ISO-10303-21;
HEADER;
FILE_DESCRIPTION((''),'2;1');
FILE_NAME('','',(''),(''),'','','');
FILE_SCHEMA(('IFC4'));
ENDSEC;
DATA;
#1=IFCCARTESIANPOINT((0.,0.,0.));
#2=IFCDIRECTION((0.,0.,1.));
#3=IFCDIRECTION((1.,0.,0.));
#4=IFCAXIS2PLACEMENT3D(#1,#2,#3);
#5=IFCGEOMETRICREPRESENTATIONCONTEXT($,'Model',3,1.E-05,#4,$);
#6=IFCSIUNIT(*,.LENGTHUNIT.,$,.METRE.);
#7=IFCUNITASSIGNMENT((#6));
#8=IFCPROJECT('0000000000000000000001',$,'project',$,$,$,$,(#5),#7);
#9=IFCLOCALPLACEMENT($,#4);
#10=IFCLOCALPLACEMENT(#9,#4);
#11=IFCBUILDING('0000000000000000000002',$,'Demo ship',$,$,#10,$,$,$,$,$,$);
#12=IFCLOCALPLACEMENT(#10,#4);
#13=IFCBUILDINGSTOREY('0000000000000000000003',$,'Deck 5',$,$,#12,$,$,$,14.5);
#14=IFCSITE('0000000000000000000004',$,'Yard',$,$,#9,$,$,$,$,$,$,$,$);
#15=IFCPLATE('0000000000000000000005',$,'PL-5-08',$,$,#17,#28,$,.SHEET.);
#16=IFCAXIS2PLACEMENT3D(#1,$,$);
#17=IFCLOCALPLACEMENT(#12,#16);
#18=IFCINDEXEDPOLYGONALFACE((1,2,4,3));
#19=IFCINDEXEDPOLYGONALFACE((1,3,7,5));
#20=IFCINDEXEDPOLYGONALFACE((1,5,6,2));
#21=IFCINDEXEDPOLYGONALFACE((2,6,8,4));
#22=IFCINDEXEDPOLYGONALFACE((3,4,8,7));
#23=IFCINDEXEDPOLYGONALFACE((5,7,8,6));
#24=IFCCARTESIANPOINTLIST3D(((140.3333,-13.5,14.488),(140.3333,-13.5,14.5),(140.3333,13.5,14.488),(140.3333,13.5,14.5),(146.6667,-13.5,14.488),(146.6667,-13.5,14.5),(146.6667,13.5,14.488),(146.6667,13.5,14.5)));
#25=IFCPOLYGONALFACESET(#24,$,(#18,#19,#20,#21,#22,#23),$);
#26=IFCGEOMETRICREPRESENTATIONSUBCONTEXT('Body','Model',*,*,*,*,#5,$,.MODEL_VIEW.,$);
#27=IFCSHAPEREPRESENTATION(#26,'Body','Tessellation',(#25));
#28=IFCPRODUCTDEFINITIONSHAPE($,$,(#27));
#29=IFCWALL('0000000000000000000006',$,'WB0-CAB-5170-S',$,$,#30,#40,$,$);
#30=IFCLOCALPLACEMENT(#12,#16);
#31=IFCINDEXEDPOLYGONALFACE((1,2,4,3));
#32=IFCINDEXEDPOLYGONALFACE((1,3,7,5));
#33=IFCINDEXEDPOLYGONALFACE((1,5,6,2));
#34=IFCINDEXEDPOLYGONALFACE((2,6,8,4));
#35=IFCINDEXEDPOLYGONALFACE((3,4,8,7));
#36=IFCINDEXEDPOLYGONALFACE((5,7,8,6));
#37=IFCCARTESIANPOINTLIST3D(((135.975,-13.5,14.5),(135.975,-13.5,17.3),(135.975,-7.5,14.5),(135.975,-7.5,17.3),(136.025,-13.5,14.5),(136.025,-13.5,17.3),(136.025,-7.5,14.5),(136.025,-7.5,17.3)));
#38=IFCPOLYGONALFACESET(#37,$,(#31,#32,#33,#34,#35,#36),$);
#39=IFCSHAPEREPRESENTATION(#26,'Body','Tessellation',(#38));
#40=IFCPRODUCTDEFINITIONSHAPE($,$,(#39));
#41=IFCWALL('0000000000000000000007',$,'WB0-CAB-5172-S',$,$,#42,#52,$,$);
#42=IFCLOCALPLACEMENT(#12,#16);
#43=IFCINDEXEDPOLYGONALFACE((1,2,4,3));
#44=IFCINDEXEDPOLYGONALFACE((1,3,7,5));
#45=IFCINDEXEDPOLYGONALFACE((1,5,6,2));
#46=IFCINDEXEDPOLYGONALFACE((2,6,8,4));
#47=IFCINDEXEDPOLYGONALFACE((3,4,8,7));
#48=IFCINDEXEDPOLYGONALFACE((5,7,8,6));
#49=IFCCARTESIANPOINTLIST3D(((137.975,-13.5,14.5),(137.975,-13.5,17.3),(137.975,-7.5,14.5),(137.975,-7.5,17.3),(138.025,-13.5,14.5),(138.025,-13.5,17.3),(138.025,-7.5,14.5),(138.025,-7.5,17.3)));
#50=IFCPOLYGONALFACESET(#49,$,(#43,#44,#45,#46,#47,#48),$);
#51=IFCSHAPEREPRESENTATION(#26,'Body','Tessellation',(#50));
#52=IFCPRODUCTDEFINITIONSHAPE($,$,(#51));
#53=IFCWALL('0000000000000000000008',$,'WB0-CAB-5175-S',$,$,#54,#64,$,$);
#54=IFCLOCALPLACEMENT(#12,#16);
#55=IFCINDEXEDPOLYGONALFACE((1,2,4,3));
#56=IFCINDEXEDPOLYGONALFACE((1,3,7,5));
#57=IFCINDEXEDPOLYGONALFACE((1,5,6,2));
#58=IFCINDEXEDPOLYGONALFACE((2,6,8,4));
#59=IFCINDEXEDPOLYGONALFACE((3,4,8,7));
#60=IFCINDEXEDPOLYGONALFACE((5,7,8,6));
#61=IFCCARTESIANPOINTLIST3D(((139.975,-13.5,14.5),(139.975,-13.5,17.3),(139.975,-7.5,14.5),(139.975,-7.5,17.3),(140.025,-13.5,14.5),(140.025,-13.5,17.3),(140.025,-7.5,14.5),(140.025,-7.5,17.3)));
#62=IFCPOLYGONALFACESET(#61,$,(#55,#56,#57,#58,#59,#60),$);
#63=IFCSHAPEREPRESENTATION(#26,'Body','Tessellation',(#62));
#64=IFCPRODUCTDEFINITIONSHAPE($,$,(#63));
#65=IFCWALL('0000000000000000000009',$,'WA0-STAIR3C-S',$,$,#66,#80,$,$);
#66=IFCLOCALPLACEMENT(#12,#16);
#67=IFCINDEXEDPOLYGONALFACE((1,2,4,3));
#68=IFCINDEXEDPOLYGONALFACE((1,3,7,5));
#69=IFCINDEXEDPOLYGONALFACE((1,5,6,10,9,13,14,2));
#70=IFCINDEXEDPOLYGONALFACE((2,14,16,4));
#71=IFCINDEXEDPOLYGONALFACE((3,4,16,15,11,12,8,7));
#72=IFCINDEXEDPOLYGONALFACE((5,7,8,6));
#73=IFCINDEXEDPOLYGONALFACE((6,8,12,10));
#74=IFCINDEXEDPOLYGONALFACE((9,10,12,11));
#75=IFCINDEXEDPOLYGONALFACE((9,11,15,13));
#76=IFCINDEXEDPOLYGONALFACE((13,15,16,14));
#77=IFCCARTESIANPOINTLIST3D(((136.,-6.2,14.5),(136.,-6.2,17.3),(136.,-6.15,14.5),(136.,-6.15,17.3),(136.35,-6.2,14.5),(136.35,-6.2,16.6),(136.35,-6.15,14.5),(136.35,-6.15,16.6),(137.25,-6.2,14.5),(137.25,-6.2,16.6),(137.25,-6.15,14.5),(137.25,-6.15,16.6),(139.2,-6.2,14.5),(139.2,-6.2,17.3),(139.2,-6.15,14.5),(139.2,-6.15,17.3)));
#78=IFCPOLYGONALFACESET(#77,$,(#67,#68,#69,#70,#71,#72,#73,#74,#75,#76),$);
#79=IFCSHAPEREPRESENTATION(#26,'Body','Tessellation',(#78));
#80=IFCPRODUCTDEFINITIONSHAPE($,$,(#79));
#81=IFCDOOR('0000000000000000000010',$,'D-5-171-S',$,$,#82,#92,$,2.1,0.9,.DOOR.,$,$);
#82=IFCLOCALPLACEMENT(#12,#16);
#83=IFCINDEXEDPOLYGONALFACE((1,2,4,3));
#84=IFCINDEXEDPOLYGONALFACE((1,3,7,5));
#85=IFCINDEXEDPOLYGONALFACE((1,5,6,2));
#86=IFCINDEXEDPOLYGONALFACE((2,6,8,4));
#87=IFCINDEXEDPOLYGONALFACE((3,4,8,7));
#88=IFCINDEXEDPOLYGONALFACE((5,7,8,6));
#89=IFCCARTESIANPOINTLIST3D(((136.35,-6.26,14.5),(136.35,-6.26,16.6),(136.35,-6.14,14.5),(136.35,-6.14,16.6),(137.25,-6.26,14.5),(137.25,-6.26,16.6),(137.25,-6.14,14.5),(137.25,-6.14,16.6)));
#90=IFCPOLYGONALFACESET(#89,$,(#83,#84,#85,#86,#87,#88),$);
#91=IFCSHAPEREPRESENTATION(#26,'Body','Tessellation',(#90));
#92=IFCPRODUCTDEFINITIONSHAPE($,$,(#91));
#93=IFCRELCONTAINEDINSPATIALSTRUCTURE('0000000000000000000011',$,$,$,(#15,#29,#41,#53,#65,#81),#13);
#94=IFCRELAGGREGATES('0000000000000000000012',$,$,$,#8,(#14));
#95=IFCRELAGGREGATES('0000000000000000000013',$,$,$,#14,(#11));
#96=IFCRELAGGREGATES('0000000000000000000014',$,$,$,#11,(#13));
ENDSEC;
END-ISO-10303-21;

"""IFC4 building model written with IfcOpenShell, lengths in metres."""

from ifc_helpers import new_model, si_unit, frame, frame_2d, origin, origin_with_axes, place, context, subcontext, project, spatial, rectangle, extrude, element, fill, save


model = new_model("IFC4")

# Units and contexts
model_context = context("Model", 3, precision=1e-05, world=origin_with_axes())
body_context = subcontext(model_context, "Body", "Model", "MODEL_VIEW")
ifc_project = project(units=[si_unit("LENGTHUNIT", "METRE")], contexts=[model_context])

# Site, building, storey
site_placement = place(None, origin_with_axes())
site = spatial("IfcSite", under=ifc_project, at=site_placement, Name="Yard")
building_placement = place(site_placement, origin_with_axes())
building = spatial("IfcBuilding", under=site, at=building_placement, Name="Demo ship")
storey_placement = place(building_placement, origin_with_axes())
storey = spatial("IfcBuildingStorey", under=building, at=storey_placement, Name="Deck 5", Elevation=14.5)

# Plate
plate_placement = place(storey_placement, frame((140.3333, -13.5, 14.488), z_axis=(0.0, 0.0, 1.0), x_axis=(1.0, 0.0, 0.0)))
element("IfcPlate", 1, at=plate_placement, inside=storey, Name="PL-5-08", PredefinedType="SHEET", context=body_context, shape_type="SweptSolid", body=[
    extrude(rectangle(XDim=6.3334, YDim=27.0, at=frame_2d((3.1667, 13.5))), origin(), (0.0, 0.0, 1.0), 0.012),
])

# Walls
for number, where, z_axis, x_axis, name in (
    (2, (135.975, -13.5, 14.5), (0.0, 0.0, 1.0), (1.0, 0.0, 0.0), "WB0-CAB-5170-S"),
    (3, (137.975, -13.5, 14.5), (0.0, 0.0, 1.0), (1.0, 0.0, 0.0), "WB0-CAB-5172-S"),
    (4, (139.975, -13.5, 14.5), (0.0, 0.0, 1.0), (1.0, 0.0, 0.0), "WB0-CAB-5175-S"),
):
    element("IfcWall", number, at=place(storey_placement, frame(where, z_axis=z_axis, x_axis=x_axis)), inside=storey, Name=name, context=body_context, shape_type="SweptSolid", body=[
        extrude(rectangle(XDim=0.05, YDim=6.0, at=frame_2d((0.025, 3.0))), origin(), (0.0, 0.0, 1.0), 2.8),
    ])

# Wall, opening, door
wall_1_placement = place(storey_placement, frame((136.0, -6.2, 14.5), z_axis=(0.0, 0.0, 1.0), x_axis=(1.0, 0.0, 0.0)))
wall_1 = element("IfcWall", 5, at=wall_1_placement, inside=storey, Name="WA0-STAIR3C-S", context=body_context, shape_type="SweptSolid", body=[
    extrude(rectangle(XDim=3.2, YDim=0.05, at=frame_2d((1.6, 0.025))), origin(), (0.0, 0.0, 1.0), 2.8),
])
opening_1_placement = place(None, frame((136.35, -6.26, 14.5), z_axis=(0.0, 0.0, 1.0), x_axis=(1.0, 0.0, 0.0)))
opening_1 = element("IfcOpeningElement", 6, at=opening_1_placement, cuts=wall_1, context=body_context, shape_type="SweptSolid", body=[
    extrude(rectangle(XDim=0.9, YDim=0.12, at=frame_2d((0.45, 0.06))), origin(), (0.0, 0.0, 1.0), 2.1),
])
door_1_placement = place(storey_placement, frame((136.35, -6.26, 14.5), z_axis=(0.0, 0.0, 1.0), x_axis=(1.0, 0.0, 0.0)))
door_1 = element("IfcDoor", 7, at=door_1_placement, inside=storey, Name="D-5-171-S", OverallHeight=2.1, OverallWidth=0.9, PredefinedType="DOOR", context=body_context, shape_type="SweptSolid", body=[
    extrude(rectangle(XDim=0.9, YDim=0.12, at=frame_2d((0.45, 0.06))), origin(), (0.0, 0.0, 1.0), 2.1),
])
fill(opening_1, door_1)

save(model, "model.ifc")
